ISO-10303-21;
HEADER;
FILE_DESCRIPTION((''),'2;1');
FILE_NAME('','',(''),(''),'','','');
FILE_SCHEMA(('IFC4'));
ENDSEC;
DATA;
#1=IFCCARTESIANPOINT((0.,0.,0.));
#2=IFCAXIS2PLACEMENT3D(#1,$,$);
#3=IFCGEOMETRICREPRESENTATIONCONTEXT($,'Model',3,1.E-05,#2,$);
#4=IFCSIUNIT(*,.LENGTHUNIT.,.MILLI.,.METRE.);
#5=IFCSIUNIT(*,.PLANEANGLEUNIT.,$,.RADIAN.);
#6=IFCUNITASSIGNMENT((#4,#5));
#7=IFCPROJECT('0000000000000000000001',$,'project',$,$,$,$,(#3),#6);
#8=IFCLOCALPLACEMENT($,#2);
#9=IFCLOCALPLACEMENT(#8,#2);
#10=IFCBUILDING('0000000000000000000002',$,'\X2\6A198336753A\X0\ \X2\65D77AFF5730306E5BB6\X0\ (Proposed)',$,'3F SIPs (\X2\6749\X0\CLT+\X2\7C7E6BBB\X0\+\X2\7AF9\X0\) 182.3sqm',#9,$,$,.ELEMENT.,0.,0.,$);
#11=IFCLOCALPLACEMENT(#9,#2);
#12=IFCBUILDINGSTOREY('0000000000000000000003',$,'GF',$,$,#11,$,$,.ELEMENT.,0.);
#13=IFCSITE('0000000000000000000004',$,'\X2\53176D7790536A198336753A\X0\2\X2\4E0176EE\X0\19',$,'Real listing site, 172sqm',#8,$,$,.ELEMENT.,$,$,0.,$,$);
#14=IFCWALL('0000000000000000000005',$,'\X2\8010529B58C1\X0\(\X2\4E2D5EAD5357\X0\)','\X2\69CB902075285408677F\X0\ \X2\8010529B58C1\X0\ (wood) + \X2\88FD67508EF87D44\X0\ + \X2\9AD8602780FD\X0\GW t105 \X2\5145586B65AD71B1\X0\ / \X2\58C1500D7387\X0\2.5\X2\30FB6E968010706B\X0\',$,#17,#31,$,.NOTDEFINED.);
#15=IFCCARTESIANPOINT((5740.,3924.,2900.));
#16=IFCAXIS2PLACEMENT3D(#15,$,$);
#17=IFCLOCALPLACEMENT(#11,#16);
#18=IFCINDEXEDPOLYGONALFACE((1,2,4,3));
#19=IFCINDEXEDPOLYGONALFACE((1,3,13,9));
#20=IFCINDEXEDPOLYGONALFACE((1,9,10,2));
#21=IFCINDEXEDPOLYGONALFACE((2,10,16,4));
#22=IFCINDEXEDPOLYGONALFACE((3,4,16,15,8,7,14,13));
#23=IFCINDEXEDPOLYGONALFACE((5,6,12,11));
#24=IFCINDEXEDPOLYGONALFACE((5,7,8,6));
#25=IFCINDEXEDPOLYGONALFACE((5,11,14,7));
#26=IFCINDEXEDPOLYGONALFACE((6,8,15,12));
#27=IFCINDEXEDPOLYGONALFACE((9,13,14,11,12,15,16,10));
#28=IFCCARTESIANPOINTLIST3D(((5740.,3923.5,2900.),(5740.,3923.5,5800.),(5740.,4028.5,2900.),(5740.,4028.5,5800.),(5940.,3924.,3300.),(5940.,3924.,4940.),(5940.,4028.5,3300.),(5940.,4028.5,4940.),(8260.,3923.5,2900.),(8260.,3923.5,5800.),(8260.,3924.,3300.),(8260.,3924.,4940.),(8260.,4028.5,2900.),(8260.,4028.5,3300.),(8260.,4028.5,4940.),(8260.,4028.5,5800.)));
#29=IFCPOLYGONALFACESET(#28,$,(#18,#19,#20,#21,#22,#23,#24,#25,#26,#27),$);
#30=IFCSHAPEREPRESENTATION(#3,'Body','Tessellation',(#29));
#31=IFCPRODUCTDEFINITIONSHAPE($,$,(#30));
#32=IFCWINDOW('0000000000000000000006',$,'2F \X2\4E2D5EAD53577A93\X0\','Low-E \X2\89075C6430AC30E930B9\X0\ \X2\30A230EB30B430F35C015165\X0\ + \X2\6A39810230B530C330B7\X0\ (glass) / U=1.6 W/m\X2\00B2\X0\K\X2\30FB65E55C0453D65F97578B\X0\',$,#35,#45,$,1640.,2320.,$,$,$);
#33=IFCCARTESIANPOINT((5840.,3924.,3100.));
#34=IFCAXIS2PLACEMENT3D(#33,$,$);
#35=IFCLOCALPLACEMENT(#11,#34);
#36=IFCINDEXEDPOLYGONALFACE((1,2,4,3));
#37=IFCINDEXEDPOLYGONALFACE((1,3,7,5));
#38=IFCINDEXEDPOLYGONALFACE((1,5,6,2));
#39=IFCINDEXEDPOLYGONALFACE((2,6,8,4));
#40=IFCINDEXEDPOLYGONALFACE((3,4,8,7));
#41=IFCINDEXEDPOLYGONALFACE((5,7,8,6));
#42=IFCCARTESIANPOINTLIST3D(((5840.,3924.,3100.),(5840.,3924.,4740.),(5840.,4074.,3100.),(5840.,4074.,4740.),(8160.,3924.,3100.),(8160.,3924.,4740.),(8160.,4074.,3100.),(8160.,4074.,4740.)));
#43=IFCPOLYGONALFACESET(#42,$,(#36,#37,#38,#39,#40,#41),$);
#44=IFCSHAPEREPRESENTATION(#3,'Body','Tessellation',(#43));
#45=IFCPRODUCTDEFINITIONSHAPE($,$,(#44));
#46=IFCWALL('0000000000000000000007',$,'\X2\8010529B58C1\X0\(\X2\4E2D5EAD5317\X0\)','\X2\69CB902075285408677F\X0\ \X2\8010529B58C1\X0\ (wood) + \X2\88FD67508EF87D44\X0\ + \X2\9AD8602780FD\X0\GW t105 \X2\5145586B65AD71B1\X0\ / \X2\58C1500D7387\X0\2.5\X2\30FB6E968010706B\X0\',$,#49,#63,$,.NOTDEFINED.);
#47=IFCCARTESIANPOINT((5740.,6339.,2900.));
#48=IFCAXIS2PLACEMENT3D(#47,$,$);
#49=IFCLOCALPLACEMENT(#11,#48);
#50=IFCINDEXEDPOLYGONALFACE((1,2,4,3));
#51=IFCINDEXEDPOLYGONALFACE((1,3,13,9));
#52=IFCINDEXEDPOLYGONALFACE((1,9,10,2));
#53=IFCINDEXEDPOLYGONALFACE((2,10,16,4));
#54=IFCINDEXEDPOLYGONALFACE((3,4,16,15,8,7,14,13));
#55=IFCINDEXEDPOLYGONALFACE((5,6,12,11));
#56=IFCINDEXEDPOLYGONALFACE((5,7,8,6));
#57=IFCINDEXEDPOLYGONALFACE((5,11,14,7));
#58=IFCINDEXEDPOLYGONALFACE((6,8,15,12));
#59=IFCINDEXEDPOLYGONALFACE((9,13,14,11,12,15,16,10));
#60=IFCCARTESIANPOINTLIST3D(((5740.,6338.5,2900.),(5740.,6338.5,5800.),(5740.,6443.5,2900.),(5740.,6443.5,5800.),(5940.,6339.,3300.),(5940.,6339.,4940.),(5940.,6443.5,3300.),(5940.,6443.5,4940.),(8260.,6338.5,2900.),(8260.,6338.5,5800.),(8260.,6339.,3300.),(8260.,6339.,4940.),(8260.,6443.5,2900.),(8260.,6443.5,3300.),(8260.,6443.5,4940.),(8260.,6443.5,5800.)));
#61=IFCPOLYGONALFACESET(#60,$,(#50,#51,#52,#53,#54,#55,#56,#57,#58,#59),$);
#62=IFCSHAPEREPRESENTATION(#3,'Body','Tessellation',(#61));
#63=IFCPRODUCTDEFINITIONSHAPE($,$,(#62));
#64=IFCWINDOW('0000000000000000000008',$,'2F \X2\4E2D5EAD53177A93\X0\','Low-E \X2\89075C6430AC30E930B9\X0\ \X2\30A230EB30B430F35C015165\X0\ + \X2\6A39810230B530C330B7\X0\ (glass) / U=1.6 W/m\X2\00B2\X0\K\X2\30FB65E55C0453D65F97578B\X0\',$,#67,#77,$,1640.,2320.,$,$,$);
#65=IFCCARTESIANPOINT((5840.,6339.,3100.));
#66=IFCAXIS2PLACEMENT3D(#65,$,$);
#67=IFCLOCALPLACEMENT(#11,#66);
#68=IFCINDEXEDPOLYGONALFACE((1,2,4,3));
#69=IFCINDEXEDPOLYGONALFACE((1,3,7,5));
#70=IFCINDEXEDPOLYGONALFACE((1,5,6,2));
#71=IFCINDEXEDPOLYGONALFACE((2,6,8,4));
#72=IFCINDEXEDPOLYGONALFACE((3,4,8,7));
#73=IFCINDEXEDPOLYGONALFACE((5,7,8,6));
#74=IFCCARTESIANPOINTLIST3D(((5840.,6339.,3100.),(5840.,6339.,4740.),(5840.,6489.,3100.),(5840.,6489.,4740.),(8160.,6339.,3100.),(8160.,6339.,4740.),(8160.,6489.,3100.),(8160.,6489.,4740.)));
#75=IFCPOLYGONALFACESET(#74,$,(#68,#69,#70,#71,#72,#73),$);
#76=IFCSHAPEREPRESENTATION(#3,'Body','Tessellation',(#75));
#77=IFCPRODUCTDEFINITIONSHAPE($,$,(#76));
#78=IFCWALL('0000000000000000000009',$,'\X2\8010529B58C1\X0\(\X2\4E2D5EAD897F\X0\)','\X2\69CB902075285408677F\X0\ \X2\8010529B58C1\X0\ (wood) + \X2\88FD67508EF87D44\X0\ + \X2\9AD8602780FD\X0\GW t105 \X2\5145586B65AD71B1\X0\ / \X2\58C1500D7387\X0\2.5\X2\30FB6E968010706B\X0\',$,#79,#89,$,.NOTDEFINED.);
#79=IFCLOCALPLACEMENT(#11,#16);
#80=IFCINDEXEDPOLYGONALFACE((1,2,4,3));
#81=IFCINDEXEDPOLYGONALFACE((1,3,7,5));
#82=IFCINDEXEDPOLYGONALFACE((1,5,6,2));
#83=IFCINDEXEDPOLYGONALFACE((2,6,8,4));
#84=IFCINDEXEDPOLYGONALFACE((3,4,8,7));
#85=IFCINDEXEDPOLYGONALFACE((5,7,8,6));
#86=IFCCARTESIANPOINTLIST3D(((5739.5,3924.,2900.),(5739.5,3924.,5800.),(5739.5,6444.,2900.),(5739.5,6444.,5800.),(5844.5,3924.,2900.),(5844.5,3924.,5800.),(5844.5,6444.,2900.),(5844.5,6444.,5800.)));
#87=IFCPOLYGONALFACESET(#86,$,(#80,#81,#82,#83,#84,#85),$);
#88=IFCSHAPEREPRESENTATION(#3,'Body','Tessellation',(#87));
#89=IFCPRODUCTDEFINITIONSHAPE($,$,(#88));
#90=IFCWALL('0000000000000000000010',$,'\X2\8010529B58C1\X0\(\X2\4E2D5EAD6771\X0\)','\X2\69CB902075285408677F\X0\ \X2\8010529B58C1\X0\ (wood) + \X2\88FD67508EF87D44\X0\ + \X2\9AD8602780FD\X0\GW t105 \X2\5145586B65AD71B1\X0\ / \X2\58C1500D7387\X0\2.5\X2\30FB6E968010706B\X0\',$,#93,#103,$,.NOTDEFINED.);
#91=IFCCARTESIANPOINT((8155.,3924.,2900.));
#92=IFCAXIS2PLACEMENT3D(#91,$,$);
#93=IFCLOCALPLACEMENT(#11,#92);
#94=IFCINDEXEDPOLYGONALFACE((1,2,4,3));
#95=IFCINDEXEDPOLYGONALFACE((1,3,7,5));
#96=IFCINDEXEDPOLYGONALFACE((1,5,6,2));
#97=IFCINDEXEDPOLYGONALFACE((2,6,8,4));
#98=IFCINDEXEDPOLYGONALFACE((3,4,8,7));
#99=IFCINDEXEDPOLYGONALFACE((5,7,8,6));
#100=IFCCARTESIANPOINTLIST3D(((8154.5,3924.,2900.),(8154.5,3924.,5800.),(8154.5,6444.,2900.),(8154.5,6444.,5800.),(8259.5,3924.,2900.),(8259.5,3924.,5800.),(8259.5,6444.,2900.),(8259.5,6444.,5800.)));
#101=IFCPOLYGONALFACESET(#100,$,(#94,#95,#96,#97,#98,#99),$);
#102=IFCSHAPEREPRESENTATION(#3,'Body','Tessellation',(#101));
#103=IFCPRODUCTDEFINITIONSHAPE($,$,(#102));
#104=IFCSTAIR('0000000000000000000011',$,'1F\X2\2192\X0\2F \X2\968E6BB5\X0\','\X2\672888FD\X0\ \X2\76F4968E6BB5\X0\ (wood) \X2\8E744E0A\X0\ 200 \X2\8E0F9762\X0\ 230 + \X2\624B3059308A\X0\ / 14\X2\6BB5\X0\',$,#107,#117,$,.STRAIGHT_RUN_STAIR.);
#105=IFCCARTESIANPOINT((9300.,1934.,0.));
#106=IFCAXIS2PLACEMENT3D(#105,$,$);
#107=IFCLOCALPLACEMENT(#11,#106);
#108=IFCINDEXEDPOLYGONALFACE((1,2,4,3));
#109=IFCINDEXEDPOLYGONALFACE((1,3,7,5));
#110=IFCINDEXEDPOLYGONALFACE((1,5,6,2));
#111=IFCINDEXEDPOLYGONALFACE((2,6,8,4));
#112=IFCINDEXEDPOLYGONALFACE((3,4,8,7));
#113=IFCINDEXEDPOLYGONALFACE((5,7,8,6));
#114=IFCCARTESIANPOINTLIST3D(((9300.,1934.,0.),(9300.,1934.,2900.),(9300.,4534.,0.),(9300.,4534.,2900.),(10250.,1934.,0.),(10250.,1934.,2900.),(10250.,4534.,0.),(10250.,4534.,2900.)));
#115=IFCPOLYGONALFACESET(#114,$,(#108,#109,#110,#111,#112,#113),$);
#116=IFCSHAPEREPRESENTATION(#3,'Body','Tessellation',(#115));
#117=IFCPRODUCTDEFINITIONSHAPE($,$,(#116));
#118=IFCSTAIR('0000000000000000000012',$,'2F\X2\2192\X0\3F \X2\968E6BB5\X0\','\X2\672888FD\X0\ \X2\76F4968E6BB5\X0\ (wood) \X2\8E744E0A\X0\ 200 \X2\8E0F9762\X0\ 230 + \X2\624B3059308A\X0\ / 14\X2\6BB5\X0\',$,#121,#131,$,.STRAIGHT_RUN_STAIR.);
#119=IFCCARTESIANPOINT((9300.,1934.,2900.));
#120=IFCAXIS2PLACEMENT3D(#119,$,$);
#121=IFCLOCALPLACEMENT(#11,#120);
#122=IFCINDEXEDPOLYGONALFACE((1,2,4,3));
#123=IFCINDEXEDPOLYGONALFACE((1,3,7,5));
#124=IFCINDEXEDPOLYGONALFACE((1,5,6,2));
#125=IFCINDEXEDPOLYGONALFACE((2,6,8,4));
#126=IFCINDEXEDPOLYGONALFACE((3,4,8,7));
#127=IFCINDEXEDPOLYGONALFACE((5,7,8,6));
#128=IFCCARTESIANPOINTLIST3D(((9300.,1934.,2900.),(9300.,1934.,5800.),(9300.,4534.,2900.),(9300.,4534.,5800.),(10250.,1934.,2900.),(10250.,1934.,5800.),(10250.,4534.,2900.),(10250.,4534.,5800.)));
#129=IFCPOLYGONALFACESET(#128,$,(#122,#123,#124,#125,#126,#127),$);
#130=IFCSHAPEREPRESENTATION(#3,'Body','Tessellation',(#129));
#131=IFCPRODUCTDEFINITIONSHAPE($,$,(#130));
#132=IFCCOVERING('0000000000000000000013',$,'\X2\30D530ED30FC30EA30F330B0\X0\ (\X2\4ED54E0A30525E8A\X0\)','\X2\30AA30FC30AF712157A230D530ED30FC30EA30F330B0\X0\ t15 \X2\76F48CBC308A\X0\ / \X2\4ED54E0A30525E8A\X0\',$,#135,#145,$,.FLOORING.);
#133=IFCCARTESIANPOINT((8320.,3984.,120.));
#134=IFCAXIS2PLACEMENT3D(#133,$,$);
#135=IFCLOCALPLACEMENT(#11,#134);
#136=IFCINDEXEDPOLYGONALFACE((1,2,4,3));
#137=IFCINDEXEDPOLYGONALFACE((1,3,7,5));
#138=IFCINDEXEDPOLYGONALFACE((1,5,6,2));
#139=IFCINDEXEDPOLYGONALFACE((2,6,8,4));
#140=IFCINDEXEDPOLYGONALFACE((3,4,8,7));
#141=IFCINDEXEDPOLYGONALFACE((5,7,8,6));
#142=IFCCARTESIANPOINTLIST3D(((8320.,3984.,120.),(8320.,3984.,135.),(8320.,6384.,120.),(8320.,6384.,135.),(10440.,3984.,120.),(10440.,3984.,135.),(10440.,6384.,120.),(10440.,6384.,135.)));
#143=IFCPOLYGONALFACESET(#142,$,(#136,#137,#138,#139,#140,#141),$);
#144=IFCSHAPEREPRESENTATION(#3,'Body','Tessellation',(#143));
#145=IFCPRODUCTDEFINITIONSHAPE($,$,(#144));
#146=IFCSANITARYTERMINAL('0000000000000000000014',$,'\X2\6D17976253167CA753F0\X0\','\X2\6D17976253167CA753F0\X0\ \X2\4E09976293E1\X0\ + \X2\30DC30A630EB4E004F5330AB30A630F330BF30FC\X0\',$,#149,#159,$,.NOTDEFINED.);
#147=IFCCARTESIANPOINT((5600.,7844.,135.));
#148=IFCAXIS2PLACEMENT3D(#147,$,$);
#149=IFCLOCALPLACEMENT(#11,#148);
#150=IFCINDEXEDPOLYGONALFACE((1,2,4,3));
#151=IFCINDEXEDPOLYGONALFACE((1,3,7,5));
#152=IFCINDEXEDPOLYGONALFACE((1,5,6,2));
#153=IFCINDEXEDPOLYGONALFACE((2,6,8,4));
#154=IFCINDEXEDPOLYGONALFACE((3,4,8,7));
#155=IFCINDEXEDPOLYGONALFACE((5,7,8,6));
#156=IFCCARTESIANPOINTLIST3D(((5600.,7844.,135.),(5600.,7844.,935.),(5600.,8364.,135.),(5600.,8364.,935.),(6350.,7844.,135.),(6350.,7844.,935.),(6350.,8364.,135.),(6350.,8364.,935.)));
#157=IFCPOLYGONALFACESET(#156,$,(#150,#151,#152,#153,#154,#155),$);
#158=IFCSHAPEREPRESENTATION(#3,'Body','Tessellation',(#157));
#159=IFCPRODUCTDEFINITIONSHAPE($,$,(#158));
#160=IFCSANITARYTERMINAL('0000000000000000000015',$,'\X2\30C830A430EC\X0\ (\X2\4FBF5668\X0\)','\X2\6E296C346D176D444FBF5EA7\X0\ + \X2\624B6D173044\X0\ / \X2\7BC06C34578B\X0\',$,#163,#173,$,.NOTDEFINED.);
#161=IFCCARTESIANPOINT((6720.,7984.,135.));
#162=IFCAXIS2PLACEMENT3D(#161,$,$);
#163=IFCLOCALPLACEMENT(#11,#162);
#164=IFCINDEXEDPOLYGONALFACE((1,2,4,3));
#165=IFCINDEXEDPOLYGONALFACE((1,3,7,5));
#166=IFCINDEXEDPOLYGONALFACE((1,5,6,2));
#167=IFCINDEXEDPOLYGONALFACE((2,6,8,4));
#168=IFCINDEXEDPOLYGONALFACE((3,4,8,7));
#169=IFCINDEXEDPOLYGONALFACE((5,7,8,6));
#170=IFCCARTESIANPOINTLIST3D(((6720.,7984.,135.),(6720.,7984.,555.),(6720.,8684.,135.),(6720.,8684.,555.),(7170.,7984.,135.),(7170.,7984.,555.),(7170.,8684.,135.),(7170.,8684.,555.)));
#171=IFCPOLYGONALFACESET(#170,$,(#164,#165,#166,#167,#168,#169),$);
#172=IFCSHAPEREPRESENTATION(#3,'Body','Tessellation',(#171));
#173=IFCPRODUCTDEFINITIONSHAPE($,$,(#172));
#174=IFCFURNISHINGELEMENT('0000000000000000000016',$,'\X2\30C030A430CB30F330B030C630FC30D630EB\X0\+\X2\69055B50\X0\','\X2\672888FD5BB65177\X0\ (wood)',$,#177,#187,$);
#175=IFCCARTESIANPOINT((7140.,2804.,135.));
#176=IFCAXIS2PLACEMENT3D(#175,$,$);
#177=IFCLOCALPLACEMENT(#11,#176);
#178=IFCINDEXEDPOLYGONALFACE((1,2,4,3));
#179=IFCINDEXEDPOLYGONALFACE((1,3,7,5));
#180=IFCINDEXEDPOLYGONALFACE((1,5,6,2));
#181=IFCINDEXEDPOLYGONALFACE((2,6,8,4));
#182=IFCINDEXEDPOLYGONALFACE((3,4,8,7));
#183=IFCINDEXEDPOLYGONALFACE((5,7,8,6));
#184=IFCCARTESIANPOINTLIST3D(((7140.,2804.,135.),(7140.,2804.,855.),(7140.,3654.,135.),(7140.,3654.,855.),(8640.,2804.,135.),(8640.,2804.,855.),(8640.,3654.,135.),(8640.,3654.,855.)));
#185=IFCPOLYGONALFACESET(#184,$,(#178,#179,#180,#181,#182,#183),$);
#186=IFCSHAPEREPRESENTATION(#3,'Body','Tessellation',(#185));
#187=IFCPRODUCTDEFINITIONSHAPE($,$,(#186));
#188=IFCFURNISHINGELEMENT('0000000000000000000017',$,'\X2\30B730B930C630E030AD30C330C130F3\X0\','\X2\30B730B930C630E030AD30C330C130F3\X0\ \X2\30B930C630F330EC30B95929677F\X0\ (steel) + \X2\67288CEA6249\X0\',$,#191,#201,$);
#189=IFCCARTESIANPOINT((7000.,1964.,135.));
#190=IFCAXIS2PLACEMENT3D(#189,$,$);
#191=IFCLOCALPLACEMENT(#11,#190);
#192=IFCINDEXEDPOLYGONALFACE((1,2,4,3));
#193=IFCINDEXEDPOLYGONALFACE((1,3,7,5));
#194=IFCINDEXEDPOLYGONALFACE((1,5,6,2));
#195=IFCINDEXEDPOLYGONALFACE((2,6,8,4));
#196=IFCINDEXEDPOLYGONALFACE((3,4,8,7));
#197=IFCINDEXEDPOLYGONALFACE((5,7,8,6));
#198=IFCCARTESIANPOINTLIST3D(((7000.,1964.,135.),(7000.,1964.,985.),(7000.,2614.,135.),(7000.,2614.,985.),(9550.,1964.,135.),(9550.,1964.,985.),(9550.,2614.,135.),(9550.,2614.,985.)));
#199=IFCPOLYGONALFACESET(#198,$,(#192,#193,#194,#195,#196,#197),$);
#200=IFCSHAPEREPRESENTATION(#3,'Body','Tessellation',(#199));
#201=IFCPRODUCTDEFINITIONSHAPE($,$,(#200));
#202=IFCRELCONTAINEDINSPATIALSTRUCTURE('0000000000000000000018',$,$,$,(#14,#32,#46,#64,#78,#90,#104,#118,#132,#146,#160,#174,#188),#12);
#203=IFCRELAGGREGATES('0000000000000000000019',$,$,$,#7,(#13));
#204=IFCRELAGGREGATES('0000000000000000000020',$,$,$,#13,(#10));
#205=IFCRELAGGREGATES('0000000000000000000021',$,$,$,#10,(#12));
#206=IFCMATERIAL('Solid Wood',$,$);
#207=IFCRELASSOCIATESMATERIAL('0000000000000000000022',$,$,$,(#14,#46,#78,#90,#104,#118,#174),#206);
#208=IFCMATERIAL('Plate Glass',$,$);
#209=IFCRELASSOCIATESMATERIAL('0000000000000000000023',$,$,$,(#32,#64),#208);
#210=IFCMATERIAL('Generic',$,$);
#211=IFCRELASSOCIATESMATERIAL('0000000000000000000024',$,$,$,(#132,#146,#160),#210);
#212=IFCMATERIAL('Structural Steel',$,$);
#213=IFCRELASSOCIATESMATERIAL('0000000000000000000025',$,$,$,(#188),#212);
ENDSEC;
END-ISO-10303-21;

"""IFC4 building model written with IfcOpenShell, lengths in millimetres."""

from ifc_helpers import new_model, si_unit, frame, frame_2d, origin, place, context, project, spatial, rectangle, extrude, material, element, fill, save


model = new_model("IFC4")

# Units and contexts
model_context = context("Model", 3, precision=1e-05, world=origin())
ifc_project = project(units=[si_unit("LENGTHUNIT", "METRE", prefix="MILLI"), si_unit("PLANEANGLEUNIT", "RADIAN")], contexts=[model_context])

# Site, building, storey
site_placement = place(None, origin())
site = spatial("IfcSite", under=ifc_project, at=site_placement, Name="北海道標茶町2丁目19", ObjectType="Real listing site, 172sqm", CompositionType="ELEMENT", RefElevation=0.0)
building_placement = place(site_placement, origin())
building = spatial("IfcBuilding", under=site, at=building_placement, Name="標茶町 旗竿地の家 (Proposed)", ObjectType="3F SIPs (杉CLT+籾殻+竹) 182.3sqm", CompositionType="ELEMENT", ElevationOfRefHeight=0.0, ElevationOfTerrain=0.0)
storey_placement = place(building_placement, origin())
storey = spatial("IfcBuildingStorey", under=building, at=storey_placement, Name="GF", CompositionType="ELEMENT", Elevation=0.0)

# Shared definitions
ifc_material_1 = material(Name="Solid Wood")

# Shared definitions
ifc_material_2 = material(Name="Plate Glass")

# Walls, openings, windows
wall_1_placement = place(storey_placement, frame((5740.0, 3924.0, 2900.0)))
wall_1 = element("IfcWall", 1, at=wall_1_placement, inside=storey, material=ifc_material_1, Name="耐力壁(中庭南)", Description="構造用合板 耐力壁 (wood) + 製材軸組 + 高性能GW t105 充填断熱 / 壁倍率2.5・準耐火", PredefinedType="NOTDEFINED", context=model_context, shape_type="SweptSolid", body=[
    extrude(rectangle(XDim=2520.0, YDim=105.0, at=frame_2d((1260.0, 52.0))), frame((5740.0, 3924.0, 2900.0)), (0.0, 0.0, 1.0), 2900.0),
])
opening_1_placement = place(storey_placement, frame((5840.0, 3924.0, 3100.0)))
opening_1 = element("IfcOpeningElement", 2, at=opening_1_placement, cuts=wall_1, PredefinedType="NOTDEFINED", context=model_context, shape_type="SweptSolid", body=[
    extrude(rectangle(XDim=2320.0, YDim=150.0, at=frame_2d((1160.0, 75.0))), frame((5840.0, 3924.0, 3100.0)), (0.0, 0.0, 1.0), 1640.0),
])
window_1_placement = place(storey_placement, frame((5840.0, 3924.0, 3100.0)))
window_1 = element("IfcWindow", 3, at=window_1_placement, inside=storey, material=ifc_material_2, Name="2F 中庭南窓", Description="Low-E 複層ガラス アルゴン封入 + 樹脂サッシ (glass) / U=1.6 W/m²K・日射取得型", OverallHeight=1640.0, OverallWidth=2320.0, context=model_context, shape_type="SweptSolid", body=[
    extrude(rectangle(XDim=2320.0, YDim=150.0, at=frame_2d((1160.0, 75.0))), frame((5840.0, 3924.0, 3100.0)), (0.0, 0.0, 1.0), 1640.0),
])
fill(opening_1, window_1)
wall_2_placement = place(storey_placement, frame((5740.0, 6339.0, 2900.0)))
wall_2 = element("IfcWall", 4, at=wall_2_placement, inside=storey, material=ifc_material_1, Name="耐力壁(中庭北)", Description="構造用合板 耐力壁 (wood) + 製材軸組 + 高性能GW t105 充填断熱 / 壁倍率2.5・準耐火", PredefinedType="NOTDEFINED", context=model_context, shape_type="SweptSolid", body=[
    extrude(rectangle(XDim=2520.0, YDim=105.0, at=frame_2d((1260.0, 52.0))), frame((5740.0, 6339.0, 2900.0)), (0.0, 0.0, 1.0), 2900.0),
])
opening_2_placement = place(storey_placement, frame((5840.0, 6339.0, 3100.0)))
opening_2 = element("IfcOpeningElement", 5, at=opening_2_placement, cuts=wall_2, PredefinedType="NOTDEFINED", context=model_context, shape_type="SweptSolid", body=[
    extrude(rectangle(XDim=2320.0, YDim=150.0, at=frame_2d((1160.0, 75.0))), frame((5840.0, 6339.0, 3100.0)), (0.0, 0.0, 1.0), 1640.0),
])
window_2_placement = place(storey_placement, frame((5840.0, 6339.0, 3100.0)))
window_2 = element("IfcWindow", 6, at=window_2_placement, inside=storey, material=ifc_material_2, Name="2F 中庭北窓", Description="Low-E 複層ガラス アルゴン封入 + 樹脂サッシ (glass) / U=1.6 W/m²K・日射取得型", OverallHeight=1640.0, OverallWidth=2320.0, context=model_context, shape_type="SweptSolid", body=[
    extrude(rectangle(XDim=2320.0, YDim=150.0, at=frame_2d((1160.0, 75.0))), frame((5840.0, 6339.0, 3100.0)), (0.0, 0.0, 1.0), 1640.0),
])
fill(opening_2, window_2)

# Walls
wall_3_placement = place(storey_placement, frame((5740.0, 3924.0, 2900.0)))
element("IfcWall", 7, at=wall_3_placement, inside=storey, material=ifc_material_1, Name="耐力壁(中庭西)", Description="構造用合板 耐力壁 (wood) + 製材軸組 + 高性能GW t105 充填断熱 / 壁倍率2.5・準耐火", PredefinedType="NOTDEFINED", context=model_context, shape_type="SweptSolid", body=[
    extrude(rectangle(XDim=105.0, YDim=2520.0, at=frame_2d((52.0, 1260.0))), frame((5740.0, 3924.0, 2900.0)), (0.0, 0.0, 1.0), 2900.0),
])
wall_4_placement = place(storey_placement, frame((8155.0, 3924.0, 2900.0)))
element("IfcWall", 8, at=wall_4_placement, inside=storey, material=ifc_material_1, Name="耐力壁(中庭東)", Description="構造用合板 耐力壁 (wood) + 製材軸組 + 高性能GW t105 充填断熱 / 壁倍率2.5・準耐火", PredefinedType="NOTDEFINED", context=model_context, shape_type="SweptSolid", body=[
    extrude(rectangle(XDim=105.0, YDim=2520.0, at=frame_2d((52.0, 1260.0))), frame((8155.0, 3924.0, 2900.0)), (0.0, 0.0, 1.0), 2900.0),
])

# Stairs
stair_1_placement = place(storey_placement, frame((9300.0, 1934.0, 0.0)))
element("IfcStair", 9, at=stair_1_placement, inside=storey, material=ifc_material_1, Name="1F→2F 階段", Description="木製 直階段 (wood) 蹴上 200 踏面 230 + 手すり / 14段", PredefinedType="STRAIGHT_RUN_STAIR", context=model_context, shape_type="SweptSolid", body=[
    extrude(rectangle(XDim=950.0, YDim=2600.0, at=frame_2d((475.0, 1300.0))), frame((9300.0, 1934.0, 0.0)), (0.0, 0.0, 1.0), 2900.0),
])
stair_2_placement = place(storey_placement, frame((9300.0, 1934.0, 2900.0)))
element("IfcStair", 10, at=stair_2_placement, inside=storey, material=ifc_material_1, Name="2F→3F 階段", Description="木製 直階段 (wood) 蹴上 200 踏面 230 + 手すり / 14段", PredefinedType="STRAIGHT_RUN_STAIR", context=model_context, shape_type="SweptSolid", body=[
    extrude(rectangle(XDim=950.0, YDim=2600.0, at=frame_2d((475.0, 1300.0))), frame((9300.0, 1934.0, 2900.0)), (0.0, 0.0, 1.0), 2900.0),
])

# Covering
ifc_material_3 = material(Name="Generic")
covering_placement = place(storey_placement, frame((8320.0, 3984.0, 120.0)))
element("IfcCovering", 11, at=covering_placement, inside=storey, material=ifc_material_3, Name="フローリング (仕上げ床)", Description="オーク無垢フローリング t15 直貼り / 仕上げ床", PredefinedType="FLOORING", context=model_context, shape_type="SweptSolid", body=[
    extrude(rectangle(XDim=2120.0, YDim=2400.0, at=frame_2d((1060.0, 1200.0))), frame((8320.0, 3984.0, 120.0)), (0.0, 0.0, 1.0), 15.0),
])

# Sanitary terminals
sanitary_terminal_1_placement = place(storey_placement, frame((5600.0, 7844.0, 135.0)))
element("IfcSanitaryTerminal", 12, at=sanitary_terminal_1_placement, inside=storey, material=ifc_material_3, Name="洗面化粧台", Description="洗面化粧台 三面鏡 + ボウル一体カウンター", PredefinedType="NOTDEFINED", context=model_context, shape_type="SweptSolid", body=[
    extrude(rectangle(XDim=750.0, YDim=520.0, at=frame_2d((375.0, 260.0))), frame((5600.0, 7844.0, 135.0)), (0.0, 0.0, 1.0), 800.0),
])
sanitary_terminal_2_placement = place(storey_placement, frame((6720.0, 7984.0, 135.0)))
element("IfcSanitaryTerminal", 13, at=sanitary_terminal_2_placement, inside=storey, material=ifc_material_3, Name="トイレ (便器)", Description="温水洗浄便座 + 手洗い / 節水型", PredefinedType="NOTDEFINED", context=model_context, shape_type="SweptSolid", body=[
    extrude(rectangle(XDim=450.0, YDim=700.0, at=frame_2d((225.0, 350.0))), frame((6720.0, 7984.0, 135.0)), (0.0, 0.0, 1.0), 420.0),
])

# Furnishing elements
furnishing_1_placement = place(storey_placement, frame((7140.0, 2804.0, 135.0)))
element("IfcFurnishingElement", 14, at=furnishing_1_placement, inside=storey, material=ifc_material_1, Name="ダイニングテーブル+椅子", Description="木製家具 (wood)", context=model_context, shape_type="SweptSolid", body=[
    extrude(rectangle(XDim=1500.0, YDim=850.0, at=frame_2d((750.0, 425.0))), frame((7140.0, 2804.0, 135.0)), (0.0, 0.0, 1.0), 720.0),
])
ifc_material_4 = material(Name="Structural Steel")
furnishing_2_placement = place(storey_placement, frame((7000.0, 1964.0, 135.0)))
element("IfcFurnishingElement", 15, at=furnishing_2_placement, inside=storey, material=ifc_material_4, Name="システムキッチン", Description="システムキッチン ステンレス天板 (steel) + 木質扉", context=model_context, shape_type="SweptSolid", body=[
    extrude(rectangle(XDim=2550.0, YDim=650.0, at=frame_2d((1275.0, 325.0))), frame((7000.0, 1964.0, 135.0)), (0.0, 0.0, 1.0), 850.0),
])

save(model, "model.ifc")
